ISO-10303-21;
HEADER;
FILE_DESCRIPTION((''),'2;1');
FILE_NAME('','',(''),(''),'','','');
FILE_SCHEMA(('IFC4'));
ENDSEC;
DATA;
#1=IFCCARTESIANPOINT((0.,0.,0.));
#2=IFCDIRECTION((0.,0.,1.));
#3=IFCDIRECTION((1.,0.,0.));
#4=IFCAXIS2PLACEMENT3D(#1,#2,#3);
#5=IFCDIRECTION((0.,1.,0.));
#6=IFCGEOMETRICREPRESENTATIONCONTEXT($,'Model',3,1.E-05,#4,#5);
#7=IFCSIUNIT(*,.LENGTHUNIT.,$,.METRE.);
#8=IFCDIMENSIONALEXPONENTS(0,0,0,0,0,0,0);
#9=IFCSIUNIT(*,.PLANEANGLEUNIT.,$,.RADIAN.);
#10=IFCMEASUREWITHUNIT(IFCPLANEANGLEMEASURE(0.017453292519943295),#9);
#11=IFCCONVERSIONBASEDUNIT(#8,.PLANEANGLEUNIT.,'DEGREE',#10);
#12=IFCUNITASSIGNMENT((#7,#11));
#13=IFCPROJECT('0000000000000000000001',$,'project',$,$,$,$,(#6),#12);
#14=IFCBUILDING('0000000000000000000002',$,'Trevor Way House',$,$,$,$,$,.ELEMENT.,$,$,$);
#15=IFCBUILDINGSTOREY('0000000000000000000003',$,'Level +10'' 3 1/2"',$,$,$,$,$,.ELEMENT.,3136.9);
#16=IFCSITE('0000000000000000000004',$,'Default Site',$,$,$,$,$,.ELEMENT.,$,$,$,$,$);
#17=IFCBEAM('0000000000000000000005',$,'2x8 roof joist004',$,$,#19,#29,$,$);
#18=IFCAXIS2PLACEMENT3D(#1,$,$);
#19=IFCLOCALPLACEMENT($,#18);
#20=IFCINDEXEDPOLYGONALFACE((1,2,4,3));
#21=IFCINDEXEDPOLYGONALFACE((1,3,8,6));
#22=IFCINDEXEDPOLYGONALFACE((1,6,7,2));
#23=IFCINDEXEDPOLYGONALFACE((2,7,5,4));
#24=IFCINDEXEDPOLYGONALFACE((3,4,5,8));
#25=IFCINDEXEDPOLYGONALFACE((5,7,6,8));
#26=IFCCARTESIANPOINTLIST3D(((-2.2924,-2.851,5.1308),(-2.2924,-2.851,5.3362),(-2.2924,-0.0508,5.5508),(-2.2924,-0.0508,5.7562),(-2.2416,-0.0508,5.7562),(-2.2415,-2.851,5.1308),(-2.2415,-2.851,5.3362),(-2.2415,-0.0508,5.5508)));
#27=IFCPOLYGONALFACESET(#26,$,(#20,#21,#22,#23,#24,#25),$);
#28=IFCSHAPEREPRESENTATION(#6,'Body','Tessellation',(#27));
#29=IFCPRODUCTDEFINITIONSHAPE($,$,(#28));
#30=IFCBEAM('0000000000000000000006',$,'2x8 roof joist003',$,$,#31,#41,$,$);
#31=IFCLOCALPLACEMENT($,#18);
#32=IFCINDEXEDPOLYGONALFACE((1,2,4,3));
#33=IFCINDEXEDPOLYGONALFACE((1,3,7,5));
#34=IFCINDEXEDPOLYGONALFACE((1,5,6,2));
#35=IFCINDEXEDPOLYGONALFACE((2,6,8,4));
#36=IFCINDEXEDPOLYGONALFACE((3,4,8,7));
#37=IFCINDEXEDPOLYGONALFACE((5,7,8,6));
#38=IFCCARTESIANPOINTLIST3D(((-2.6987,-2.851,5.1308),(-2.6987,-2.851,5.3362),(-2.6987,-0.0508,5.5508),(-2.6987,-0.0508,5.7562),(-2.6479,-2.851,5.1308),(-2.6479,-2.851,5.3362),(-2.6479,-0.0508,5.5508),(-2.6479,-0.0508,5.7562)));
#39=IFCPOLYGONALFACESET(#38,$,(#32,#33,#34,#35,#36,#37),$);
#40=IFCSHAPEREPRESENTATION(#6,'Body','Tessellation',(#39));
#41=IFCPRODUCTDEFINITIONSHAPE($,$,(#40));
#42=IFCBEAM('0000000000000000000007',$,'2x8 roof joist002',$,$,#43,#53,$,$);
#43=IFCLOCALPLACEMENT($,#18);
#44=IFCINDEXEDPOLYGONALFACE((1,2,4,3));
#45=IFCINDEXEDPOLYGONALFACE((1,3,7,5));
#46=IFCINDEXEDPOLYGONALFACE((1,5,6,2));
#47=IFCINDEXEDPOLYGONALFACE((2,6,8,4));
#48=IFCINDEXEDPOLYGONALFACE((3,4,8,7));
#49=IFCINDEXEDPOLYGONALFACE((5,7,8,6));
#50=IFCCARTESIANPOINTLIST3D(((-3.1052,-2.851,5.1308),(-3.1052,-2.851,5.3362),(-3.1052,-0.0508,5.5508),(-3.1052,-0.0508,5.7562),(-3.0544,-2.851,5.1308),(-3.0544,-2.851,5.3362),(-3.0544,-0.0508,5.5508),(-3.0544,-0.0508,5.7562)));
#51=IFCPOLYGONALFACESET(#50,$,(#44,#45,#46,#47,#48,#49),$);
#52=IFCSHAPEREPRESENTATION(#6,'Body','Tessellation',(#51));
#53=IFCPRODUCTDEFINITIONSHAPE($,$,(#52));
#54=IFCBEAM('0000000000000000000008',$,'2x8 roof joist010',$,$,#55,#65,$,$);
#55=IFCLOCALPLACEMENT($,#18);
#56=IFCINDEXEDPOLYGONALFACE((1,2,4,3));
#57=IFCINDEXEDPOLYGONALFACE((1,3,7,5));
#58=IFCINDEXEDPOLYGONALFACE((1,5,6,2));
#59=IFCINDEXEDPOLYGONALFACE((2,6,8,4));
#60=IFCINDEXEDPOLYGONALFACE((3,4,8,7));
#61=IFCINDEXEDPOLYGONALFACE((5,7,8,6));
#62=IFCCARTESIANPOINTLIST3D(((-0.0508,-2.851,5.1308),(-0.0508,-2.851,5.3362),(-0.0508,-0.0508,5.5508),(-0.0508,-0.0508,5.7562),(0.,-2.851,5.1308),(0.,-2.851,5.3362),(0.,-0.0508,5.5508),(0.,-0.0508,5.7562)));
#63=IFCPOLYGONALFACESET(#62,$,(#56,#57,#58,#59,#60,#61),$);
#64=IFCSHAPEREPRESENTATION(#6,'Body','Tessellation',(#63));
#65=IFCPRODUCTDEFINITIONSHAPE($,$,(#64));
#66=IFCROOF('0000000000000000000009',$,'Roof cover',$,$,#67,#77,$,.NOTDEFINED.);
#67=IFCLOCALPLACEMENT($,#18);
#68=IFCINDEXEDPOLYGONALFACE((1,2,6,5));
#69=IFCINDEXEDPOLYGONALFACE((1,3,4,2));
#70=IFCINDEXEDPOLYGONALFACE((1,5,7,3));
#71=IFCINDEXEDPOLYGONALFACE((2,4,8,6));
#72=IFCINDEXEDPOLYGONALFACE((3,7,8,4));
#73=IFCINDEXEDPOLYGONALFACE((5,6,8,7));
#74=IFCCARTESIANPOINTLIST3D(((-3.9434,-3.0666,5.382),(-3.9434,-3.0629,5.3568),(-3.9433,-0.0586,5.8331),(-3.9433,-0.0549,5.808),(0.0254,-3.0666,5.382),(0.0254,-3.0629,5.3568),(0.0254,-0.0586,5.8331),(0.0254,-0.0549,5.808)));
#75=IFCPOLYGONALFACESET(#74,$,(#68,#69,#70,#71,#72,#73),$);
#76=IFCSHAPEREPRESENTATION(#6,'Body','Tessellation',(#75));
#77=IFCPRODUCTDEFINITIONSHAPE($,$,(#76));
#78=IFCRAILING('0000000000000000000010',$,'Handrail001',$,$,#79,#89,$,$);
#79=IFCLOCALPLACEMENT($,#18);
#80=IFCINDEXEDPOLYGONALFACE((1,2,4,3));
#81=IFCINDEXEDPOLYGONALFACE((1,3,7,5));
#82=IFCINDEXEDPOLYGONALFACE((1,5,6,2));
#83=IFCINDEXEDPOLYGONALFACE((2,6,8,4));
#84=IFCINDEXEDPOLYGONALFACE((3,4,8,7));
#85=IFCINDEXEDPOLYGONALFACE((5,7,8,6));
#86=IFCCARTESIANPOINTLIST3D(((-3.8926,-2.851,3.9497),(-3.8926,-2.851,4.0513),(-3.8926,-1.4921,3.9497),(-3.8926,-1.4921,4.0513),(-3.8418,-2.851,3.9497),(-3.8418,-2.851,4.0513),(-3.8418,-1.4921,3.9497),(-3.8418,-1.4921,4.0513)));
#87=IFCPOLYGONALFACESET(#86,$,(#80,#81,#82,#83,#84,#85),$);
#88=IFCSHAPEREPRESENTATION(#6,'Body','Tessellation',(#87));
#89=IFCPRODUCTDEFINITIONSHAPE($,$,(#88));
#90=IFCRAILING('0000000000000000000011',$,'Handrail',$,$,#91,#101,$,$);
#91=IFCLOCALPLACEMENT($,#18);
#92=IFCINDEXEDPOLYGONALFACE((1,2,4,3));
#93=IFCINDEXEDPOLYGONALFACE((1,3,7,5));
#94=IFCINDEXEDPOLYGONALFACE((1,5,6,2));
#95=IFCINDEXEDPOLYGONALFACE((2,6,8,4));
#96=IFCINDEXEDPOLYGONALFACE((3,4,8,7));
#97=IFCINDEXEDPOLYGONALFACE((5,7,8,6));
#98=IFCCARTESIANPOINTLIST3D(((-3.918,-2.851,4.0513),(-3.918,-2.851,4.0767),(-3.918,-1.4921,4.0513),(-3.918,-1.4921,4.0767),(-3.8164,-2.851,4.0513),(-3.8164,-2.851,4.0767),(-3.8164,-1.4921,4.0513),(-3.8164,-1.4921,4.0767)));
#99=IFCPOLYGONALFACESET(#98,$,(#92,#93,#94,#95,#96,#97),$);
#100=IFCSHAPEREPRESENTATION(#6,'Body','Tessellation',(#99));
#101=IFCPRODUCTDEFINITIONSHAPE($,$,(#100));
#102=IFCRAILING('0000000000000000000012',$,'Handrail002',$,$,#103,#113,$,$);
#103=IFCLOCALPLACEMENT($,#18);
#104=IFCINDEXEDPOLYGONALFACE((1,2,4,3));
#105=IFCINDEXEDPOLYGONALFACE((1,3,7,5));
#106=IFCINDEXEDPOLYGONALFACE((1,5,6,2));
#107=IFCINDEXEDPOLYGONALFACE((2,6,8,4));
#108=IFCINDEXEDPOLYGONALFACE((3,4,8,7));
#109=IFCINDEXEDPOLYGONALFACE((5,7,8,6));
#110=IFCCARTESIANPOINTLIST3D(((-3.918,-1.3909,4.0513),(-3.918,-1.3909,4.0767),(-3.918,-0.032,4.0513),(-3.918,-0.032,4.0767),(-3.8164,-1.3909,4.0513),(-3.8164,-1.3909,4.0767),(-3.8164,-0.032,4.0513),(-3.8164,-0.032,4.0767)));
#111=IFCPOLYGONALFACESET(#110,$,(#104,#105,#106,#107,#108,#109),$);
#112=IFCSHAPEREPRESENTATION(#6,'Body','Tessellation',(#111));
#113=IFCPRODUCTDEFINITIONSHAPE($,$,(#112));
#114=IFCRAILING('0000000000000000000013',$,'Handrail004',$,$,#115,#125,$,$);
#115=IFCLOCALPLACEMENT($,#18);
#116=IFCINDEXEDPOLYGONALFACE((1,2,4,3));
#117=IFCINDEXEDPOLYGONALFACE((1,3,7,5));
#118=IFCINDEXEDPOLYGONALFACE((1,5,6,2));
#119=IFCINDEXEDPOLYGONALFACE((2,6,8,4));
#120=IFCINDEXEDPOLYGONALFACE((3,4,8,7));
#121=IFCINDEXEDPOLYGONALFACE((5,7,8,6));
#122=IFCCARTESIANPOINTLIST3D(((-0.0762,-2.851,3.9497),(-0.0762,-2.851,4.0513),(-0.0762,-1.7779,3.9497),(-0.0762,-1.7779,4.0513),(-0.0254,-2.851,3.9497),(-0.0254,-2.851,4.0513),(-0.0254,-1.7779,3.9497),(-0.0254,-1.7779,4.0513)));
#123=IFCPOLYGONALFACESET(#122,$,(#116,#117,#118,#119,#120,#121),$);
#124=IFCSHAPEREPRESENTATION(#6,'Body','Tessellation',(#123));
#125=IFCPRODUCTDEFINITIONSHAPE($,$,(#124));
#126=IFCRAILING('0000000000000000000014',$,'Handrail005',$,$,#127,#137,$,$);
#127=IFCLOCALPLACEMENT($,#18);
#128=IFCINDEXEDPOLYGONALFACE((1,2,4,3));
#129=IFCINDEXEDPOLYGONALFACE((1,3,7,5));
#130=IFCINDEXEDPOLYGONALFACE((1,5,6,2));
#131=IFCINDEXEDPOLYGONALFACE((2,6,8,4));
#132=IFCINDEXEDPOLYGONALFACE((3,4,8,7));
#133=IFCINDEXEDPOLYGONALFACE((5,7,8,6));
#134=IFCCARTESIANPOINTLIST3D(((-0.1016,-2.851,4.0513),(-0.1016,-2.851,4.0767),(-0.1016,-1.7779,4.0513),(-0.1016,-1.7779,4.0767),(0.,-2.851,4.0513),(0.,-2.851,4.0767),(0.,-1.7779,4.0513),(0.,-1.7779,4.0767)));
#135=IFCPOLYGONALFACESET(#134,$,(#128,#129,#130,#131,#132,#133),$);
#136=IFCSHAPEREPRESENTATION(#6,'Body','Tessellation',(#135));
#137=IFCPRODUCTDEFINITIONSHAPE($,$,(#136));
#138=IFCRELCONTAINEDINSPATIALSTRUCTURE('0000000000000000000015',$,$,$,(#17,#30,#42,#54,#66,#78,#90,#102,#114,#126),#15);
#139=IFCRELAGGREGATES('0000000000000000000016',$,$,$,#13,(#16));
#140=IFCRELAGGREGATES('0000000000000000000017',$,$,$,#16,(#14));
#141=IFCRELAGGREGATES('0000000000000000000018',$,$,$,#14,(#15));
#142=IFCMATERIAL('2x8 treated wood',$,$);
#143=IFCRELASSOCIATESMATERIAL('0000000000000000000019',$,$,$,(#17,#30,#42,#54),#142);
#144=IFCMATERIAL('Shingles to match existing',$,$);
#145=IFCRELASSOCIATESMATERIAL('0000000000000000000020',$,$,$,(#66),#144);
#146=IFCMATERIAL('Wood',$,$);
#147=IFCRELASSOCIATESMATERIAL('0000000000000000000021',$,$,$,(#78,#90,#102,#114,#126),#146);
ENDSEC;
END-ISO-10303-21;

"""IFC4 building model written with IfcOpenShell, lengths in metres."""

from ifc_helpers import new_model, entity, si_unit, converted_unit, direction, frame, origin_with_axes, place, context, project, spatial, polyline, outline, extrude, source, transform, mapped, material, element, save


model = new_model("IFC4")

# Units and contexts
model_context = context("Model", 3, precision=1e-05, world=origin_with_axes(), true_north=direction((0.0, 1.0, 0.0)))
ifc_project = project(units=[si_unit("LENGTHUNIT", "METRE"), converted_unit("PLANEANGLEUNIT", "DEGREE", entity("IfcPlaneAngleMeasure", 0.017453292519943295), si_unit("PLANEANGLEUNIT", "RADIAN"), dimensions=[0, 0, 0, 0, 0, 0, 0])], contexts=[model_context])

# Site, building, storey
site = spatial("IfcSite", under=ifc_project, Name="Default Site", CompositionType="ELEMENT")
building = spatial("IfcBuilding", under=site, Name="Trevor Way House", CompositionType="ELEMENT")
storey = spatial("IfcBuildingStorey", under=building, Name="Level +10' 3 1/2\"", CompositionType="ELEMENT", Elevation=3136.9)

# Shared definitions
placement = place(None, origin_with_axes())

# Beams
ifc_material_1 = material(Name="2x8 treated wood")
shared_shape_1 = source(origin_with_axes(), model_context, "Body", "SweptSolid", [
    extrude(outline(polyline([(-0.3127, 1.4001), (0.1073, -1.4001), (0.3127, -1.4001), (-0.1073, 1.4001), (-0.3127, 1.4001)])), frame((-3.9179, -1.4509, 5.4435), z_axis=(1.0, 0.0, 0.0), x_axis=(0.0, 0.0, -1.0)), (0.0, 0.0, 1.0), 0.0508),
])
element("IfcBeam", 1, at=placement, inside=storey, material=ifc_material_1, Name="2x8 roof joist004", context=model_context, shape_type="MappedRepresentation", body=[
    mapped(shared_shape_1, transform((1.6256, 0.0, 0.0), x_axis=(1.0, 0.0, 0.0), y_axis=(0.0, 1.0, 0.0), z_axis=(0.0, 0.0, 1.0), scale=1.0)),
])
element("IfcBeam", 2, at=placement, inside=storey, material=ifc_material_1, Name="2x8 roof joist003", context=model_context, shape_type="MappedRepresentation", body=[
    mapped(shared_shape_1, transform((1.2192, 0.0, 0.0), x_axis=(1.0, 0.0, 0.0), y_axis=(0.0, 1.0, 0.0), z_axis=(0.0, 0.0, 1.0), scale=1.0)),
])
element("IfcBeam", 3, at=placement, inside=storey, material=ifc_material_1, Name="2x8 roof joist002", context=model_context, shape_type="MappedRepresentation", body=[
    mapped(shared_shape_1, transform((0.8128, 0.0, 0.0), x_axis=(1.0, 0.0, 0.0), y_axis=(0.0, 1.0, 0.0), z_axis=(0.0, 0.0, 1.0), scale=1.0)),
])
element("IfcBeam", 4, at=placement, inside=storey, material=ifc_material_1, Name="2x8 roof joist010", context=model_context, shape_type="MappedRepresentation", body=[
    mapped(shared_shape_1, transform((3.8672, 0.0, 0.0), x_axis=(1.0, 0.0, 0.0), y_axis=(0.0, 1.0, 0.0), z_axis=(0.0, 0.0, 1.0), scale=1.0)),
])

# Roof
ifc_material_2 = material(Name="Shingles to match existing")
element("IfcRoof", 5, at=placement, inside=storey, material=ifc_material_2, Name="Roof cover", PredefinedType="NOTDEFINED", context=model_context, shape_type="SweptSolid", body=[
    extrude(outline(polyline([(0.213, 1.5059), (-0.2381, -1.5021), (-0.213, -1.5059), (0.2381, 1.5021), (0.213, 1.5059)])), frame((-3.9434, -1.5607, 5.595), z_axis=(-1.0, 0.0, 0.0), x_axis=(0.0, 0.0, 1.0)), (0.0, 0.0, -1.0), 3.9688),
])

# Railings
ifc_material_3 = material(Name="Wood")
shared_shape_2 = source(origin_with_axes(), model_context, "Body", "SweptSolid", [
    extrude(outline(polyline([(0.0254, 0.0508), (-0.0254, 0.0508), (-0.0254, -0.0508), (0.0254, -0.0508), (0.0254, 0.0508)])), frame((-3.8544, -2.851, 4.0704), z_axis=(0.0, 1.0, 0.0), x_axis=(1.0, 0.0, 0.0)), (0.0, 0.0, 1.0), 1.3589),
])
element("IfcRailing", 6, at=placement, inside=storey, material=ifc_material_3, Name="Handrail001", context=model_context, shape_type="MappedRepresentation", body=[
    mapped(shared_shape_2, transform((-0.0127, 0.0, -0.0698), x_axis=(1.0, 0.0, 0.0), y_axis=(0.0, 1.0, 0.0), z_axis=(0.0, 0.0, 1.0), scale=1.0)),
])
shared_shape_3 = source(origin_with_axes(), model_context, "Body", "SweptSolid", [
    extrude(outline(polyline([(0.0508, 0.0127), (-0.0508, 0.0127), (-0.0508, -0.0127), (0.0508, -0.0127), (0.0508, 0.0127)])), frame((-3.8672, -2.851, 4.1593), z_axis=(0.0, 1.0, 0.0), x_axis=(1.0, 0.0, 0.0)), (0.0, 0.0, 1.0), 1.3589),
])
element("IfcRailing", 7, at=placement, inside=storey, material=ifc_material_3, Name="Handrail", context=model_context, shape_type="MappedRepresentation", body=[
    mapped(shared_shape_3, transform((0.0, 0.0, -0.0953), x_axis=(1.0, 0.0, 0.0), y_axis=(0.0, 1.0, 0.0), z_axis=(0.0, 0.0, 1.0), scale=1.0)),
])
element("IfcRailing", 8, at=placement, inside=storey, material=ifc_material_3, Name="Handrail002", context=model_context, shape_type="MappedRepresentation", body=[
    mapped(shared_shape_3, transform((0.0, 1.4602, -0.0953), x_axis=(1.0, 0.0, 0.0), y_axis=(0.0, 1.0, 0.0), z_axis=(0.0, 0.0, 1.0), scale=1.0)),
])
element("IfcRailing", 9, at=placement, inside=storey, material=ifc_material_3, Name="Handrail004", context=model_context, shape_type="SweptSolid", body=[
    extrude(outline(polyline([(0.0254, 0.0508), (-0.0254, 0.0508), (-0.0254, -0.0508), (0.0254, -0.0508), (0.0254, 0.0508)])), frame((-0.0508, -2.851, 4.0005), z_axis=(0.0, 1.0, 0.0), x_axis=(1.0, 0.0, 0.0)), (0.0, 0.0, 1.0), 1.0732),
])
element("IfcRailing", 10, at=placement, inside=storey, material=ifc_material_3, Name="Handrail005", context=model_context, shape_type="SweptSolid", body=[
    extrude(outline(polyline([(0.0508, 0.0127), (-0.0508, 0.0127), (-0.0508, -0.0127), (0.0508, -0.0127), (0.0508, 0.0127)])), frame((-0.0508, -2.851, 4.064), z_axis=(0.0, 1.0, 0.0), x_axis=(1.0, 0.0, 0.0)), (0.0, 0.0, 1.0), 1.0732),
])

save(model, "model.ifc")
